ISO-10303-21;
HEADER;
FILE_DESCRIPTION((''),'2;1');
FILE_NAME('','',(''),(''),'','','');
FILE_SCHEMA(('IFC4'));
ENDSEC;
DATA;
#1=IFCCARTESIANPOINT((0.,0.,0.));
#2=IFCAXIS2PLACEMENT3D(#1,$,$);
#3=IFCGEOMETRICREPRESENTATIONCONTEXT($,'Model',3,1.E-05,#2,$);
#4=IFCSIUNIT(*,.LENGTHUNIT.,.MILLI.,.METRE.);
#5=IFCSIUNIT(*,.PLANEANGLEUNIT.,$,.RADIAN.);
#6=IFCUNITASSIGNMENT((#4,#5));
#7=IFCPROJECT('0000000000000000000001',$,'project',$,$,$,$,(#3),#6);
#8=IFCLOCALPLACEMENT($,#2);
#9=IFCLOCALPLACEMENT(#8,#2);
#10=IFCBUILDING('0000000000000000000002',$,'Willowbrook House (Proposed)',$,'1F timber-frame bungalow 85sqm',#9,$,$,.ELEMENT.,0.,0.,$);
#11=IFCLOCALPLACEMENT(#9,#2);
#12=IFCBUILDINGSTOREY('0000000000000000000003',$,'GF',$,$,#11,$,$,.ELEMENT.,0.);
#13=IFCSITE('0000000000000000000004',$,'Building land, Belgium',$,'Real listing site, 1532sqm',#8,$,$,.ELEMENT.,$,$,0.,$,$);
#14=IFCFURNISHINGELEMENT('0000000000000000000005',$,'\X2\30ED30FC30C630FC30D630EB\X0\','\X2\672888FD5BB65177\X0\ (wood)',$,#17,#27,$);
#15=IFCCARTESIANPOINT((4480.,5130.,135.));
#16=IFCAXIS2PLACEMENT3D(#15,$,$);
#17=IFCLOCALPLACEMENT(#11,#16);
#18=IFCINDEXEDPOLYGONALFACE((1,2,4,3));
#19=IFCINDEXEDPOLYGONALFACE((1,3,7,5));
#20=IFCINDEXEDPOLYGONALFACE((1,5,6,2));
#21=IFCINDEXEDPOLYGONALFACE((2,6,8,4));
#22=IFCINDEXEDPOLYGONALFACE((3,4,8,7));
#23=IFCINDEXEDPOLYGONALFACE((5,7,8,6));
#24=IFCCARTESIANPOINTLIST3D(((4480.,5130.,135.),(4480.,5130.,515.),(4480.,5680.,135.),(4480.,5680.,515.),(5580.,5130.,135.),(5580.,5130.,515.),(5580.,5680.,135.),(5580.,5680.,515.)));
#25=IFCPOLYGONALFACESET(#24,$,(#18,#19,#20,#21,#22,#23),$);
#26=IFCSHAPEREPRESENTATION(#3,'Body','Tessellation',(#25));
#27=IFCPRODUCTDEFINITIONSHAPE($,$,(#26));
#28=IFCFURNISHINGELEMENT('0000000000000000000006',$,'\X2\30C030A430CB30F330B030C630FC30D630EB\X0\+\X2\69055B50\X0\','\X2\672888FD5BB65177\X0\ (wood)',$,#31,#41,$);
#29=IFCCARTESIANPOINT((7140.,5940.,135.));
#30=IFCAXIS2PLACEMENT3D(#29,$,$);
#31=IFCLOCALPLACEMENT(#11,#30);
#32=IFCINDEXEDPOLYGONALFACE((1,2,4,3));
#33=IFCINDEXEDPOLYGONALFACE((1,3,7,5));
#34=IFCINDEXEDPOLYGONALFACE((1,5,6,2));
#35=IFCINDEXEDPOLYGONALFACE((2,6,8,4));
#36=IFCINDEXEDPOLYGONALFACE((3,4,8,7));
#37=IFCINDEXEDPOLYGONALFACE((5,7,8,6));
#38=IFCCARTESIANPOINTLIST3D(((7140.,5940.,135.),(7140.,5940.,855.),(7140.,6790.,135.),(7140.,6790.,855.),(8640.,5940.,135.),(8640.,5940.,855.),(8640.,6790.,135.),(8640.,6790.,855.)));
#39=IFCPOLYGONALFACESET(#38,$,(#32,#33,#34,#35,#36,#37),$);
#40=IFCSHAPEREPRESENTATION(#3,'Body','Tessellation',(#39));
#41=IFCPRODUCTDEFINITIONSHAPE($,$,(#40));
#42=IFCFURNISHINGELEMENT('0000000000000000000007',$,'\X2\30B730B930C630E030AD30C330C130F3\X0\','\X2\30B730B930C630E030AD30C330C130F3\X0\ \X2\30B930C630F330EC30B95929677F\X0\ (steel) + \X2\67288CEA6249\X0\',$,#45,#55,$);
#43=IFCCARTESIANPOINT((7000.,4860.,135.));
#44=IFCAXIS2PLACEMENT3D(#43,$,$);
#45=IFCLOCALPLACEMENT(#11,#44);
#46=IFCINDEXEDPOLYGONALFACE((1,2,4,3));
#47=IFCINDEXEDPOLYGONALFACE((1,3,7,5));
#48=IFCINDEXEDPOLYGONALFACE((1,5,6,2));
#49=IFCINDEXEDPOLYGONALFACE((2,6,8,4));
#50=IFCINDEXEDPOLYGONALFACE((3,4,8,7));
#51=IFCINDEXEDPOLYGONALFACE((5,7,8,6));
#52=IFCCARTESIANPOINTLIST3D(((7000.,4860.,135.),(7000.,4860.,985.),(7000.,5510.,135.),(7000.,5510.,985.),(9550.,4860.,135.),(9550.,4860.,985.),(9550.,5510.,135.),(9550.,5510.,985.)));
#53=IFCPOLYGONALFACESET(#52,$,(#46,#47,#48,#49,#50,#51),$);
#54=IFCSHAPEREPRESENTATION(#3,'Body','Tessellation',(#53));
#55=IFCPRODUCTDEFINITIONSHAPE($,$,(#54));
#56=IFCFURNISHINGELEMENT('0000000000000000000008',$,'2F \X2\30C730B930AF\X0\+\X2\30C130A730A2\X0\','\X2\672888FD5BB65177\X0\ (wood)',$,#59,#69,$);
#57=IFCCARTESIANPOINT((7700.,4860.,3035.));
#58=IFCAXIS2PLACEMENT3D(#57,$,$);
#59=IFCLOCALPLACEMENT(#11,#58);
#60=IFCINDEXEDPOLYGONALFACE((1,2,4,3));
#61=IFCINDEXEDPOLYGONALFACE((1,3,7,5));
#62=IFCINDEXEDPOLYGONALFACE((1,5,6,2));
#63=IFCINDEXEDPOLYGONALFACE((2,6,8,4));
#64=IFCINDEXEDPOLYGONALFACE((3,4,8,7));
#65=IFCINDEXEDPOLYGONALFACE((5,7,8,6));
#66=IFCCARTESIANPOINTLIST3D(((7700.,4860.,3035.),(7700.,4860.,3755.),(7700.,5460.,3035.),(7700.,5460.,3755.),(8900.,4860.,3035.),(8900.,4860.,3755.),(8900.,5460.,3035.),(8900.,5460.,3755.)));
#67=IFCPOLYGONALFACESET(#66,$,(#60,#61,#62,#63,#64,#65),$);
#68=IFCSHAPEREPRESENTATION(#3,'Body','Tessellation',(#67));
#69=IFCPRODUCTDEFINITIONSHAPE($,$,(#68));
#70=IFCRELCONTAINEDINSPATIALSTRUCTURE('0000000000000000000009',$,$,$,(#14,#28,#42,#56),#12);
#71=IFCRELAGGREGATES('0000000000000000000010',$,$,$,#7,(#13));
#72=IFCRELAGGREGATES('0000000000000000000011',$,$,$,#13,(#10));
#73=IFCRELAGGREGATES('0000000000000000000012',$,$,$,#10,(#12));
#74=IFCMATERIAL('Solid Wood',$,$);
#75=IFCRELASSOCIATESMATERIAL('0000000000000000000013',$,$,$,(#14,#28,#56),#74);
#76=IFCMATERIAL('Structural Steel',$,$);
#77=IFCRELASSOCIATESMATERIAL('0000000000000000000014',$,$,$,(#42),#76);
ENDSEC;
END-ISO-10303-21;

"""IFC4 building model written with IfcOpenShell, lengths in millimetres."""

from ifc_helpers import new_model, si_unit, frame, frame_2d, origin, place, context, project, spatial, rectangle, extrude, material, element, save


model = new_model("IFC4")

# Units and contexts
model_context = context("Model", 3, precision=1e-05, world=origin())
ifc_project = project(units=[si_unit("LENGTHUNIT", "METRE", prefix="MILLI"), si_unit("PLANEANGLEUNIT", "RADIAN")], contexts=[model_context])

# Site, building, storey
site_placement = place(None, origin())
site = spatial("IfcSite", under=ifc_project, at=site_placement, Name="Building land, Belgium", ObjectType="Real listing site, 1532sqm", CompositionType="ELEMENT", RefElevation=0.0)
building_placement = place(site_placement, origin())
building = spatial("IfcBuilding", under=site, at=building_placement, Name="Willowbrook House (Proposed)", ObjectType="1F timber-frame bungalow 85sqm", CompositionType="ELEMENT", ElevationOfRefHeight=0.0, ElevationOfTerrain=0.0)
storey_placement = place(building_placement, origin())
storey = spatial("IfcBuildingStorey", under=building, at=storey_placement, Name="GF", CompositionType="ELEMENT", Elevation=0.0)

# Shared definitions
ifc_material_1 = material(Name="Solid Wood")

# Shared definitions
ifc_material_2 = material(Name="Structural Steel")

# Furnishing elements
furnishing_1_placement = place(storey_placement, frame((4480.0, 5130.0, 135.0)))
element("IfcFurnishingElement", 1, at=furnishing_1_placement, inside=storey, material=ifc_material_1, Name="ローテーブル", Description="木製家具 (wood)", context=model_context, shape_type="SweptSolid", body=[
    extrude(rectangle(XDim=1100.0, YDim=550.0, at=frame_2d((550.0, 275.0))), frame((4480.0, 5130.0, 135.0)), (0.0, 0.0, 1.0), 380.0),
])
furnishing_2_placement = place(storey_placement, frame((7140.0, 5940.0, 135.0)))
element("IfcFurnishingElement", 2, at=furnishing_2_placement, inside=storey, material=ifc_material_1, Name="ダイニングテーブル+椅子", Description="木製家具 (wood)", context=model_context, shape_type="SweptSolid", body=[
    extrude(rectangle(XDim=1500.0, YDim=850.0, at=frame_2d((750.0, 425.0))), frame((7140.0, 5940.0, 135.0)), (0.0, 0.0, 1.0), 720.0),
])
furnishing_3_placement = place(storey_placement, frame((7000.0, 4860.0, 135.0)))
element("IfcFurnishingElement", 3, at=furnishing_3_placement, inside=storey, material=ifc_material_2, Name="システムキッチン", Description="システムキッチン ステンレス天板 (steel) + 木質扉", context=model_context, shape_type="SweptSolid", body=[
    extrude(rectangle(XDim=2550.0, YDim=650.0, at=frame_2d((1275.0, 325.0))), frame((7000.0, 4860.0, 135.0)), (0.0, 0.0, 1.0), 850.0),
])
furnishing_4_placement = place(storey_placement, frame((7700.0, 4860.0, 3035.0)))
element("IfcFurnishingElement", 4, at=furnishing_4_placement, inside=storey, material=ifc_material_1, Name="2F デスク+チェア", Description="木製家具 (wood)", context=model_context, shape_type="SweptSolid", body=[
    extrude(rectangle(XDim=1200.0, YDim=600.0, at=frame_2d((600.0, 300.0))), frame((7700.0, 4860.0, 3035.0)), (0.0, 0.0, 1.0), 720.0),
])

save(model, "model.ifc")
